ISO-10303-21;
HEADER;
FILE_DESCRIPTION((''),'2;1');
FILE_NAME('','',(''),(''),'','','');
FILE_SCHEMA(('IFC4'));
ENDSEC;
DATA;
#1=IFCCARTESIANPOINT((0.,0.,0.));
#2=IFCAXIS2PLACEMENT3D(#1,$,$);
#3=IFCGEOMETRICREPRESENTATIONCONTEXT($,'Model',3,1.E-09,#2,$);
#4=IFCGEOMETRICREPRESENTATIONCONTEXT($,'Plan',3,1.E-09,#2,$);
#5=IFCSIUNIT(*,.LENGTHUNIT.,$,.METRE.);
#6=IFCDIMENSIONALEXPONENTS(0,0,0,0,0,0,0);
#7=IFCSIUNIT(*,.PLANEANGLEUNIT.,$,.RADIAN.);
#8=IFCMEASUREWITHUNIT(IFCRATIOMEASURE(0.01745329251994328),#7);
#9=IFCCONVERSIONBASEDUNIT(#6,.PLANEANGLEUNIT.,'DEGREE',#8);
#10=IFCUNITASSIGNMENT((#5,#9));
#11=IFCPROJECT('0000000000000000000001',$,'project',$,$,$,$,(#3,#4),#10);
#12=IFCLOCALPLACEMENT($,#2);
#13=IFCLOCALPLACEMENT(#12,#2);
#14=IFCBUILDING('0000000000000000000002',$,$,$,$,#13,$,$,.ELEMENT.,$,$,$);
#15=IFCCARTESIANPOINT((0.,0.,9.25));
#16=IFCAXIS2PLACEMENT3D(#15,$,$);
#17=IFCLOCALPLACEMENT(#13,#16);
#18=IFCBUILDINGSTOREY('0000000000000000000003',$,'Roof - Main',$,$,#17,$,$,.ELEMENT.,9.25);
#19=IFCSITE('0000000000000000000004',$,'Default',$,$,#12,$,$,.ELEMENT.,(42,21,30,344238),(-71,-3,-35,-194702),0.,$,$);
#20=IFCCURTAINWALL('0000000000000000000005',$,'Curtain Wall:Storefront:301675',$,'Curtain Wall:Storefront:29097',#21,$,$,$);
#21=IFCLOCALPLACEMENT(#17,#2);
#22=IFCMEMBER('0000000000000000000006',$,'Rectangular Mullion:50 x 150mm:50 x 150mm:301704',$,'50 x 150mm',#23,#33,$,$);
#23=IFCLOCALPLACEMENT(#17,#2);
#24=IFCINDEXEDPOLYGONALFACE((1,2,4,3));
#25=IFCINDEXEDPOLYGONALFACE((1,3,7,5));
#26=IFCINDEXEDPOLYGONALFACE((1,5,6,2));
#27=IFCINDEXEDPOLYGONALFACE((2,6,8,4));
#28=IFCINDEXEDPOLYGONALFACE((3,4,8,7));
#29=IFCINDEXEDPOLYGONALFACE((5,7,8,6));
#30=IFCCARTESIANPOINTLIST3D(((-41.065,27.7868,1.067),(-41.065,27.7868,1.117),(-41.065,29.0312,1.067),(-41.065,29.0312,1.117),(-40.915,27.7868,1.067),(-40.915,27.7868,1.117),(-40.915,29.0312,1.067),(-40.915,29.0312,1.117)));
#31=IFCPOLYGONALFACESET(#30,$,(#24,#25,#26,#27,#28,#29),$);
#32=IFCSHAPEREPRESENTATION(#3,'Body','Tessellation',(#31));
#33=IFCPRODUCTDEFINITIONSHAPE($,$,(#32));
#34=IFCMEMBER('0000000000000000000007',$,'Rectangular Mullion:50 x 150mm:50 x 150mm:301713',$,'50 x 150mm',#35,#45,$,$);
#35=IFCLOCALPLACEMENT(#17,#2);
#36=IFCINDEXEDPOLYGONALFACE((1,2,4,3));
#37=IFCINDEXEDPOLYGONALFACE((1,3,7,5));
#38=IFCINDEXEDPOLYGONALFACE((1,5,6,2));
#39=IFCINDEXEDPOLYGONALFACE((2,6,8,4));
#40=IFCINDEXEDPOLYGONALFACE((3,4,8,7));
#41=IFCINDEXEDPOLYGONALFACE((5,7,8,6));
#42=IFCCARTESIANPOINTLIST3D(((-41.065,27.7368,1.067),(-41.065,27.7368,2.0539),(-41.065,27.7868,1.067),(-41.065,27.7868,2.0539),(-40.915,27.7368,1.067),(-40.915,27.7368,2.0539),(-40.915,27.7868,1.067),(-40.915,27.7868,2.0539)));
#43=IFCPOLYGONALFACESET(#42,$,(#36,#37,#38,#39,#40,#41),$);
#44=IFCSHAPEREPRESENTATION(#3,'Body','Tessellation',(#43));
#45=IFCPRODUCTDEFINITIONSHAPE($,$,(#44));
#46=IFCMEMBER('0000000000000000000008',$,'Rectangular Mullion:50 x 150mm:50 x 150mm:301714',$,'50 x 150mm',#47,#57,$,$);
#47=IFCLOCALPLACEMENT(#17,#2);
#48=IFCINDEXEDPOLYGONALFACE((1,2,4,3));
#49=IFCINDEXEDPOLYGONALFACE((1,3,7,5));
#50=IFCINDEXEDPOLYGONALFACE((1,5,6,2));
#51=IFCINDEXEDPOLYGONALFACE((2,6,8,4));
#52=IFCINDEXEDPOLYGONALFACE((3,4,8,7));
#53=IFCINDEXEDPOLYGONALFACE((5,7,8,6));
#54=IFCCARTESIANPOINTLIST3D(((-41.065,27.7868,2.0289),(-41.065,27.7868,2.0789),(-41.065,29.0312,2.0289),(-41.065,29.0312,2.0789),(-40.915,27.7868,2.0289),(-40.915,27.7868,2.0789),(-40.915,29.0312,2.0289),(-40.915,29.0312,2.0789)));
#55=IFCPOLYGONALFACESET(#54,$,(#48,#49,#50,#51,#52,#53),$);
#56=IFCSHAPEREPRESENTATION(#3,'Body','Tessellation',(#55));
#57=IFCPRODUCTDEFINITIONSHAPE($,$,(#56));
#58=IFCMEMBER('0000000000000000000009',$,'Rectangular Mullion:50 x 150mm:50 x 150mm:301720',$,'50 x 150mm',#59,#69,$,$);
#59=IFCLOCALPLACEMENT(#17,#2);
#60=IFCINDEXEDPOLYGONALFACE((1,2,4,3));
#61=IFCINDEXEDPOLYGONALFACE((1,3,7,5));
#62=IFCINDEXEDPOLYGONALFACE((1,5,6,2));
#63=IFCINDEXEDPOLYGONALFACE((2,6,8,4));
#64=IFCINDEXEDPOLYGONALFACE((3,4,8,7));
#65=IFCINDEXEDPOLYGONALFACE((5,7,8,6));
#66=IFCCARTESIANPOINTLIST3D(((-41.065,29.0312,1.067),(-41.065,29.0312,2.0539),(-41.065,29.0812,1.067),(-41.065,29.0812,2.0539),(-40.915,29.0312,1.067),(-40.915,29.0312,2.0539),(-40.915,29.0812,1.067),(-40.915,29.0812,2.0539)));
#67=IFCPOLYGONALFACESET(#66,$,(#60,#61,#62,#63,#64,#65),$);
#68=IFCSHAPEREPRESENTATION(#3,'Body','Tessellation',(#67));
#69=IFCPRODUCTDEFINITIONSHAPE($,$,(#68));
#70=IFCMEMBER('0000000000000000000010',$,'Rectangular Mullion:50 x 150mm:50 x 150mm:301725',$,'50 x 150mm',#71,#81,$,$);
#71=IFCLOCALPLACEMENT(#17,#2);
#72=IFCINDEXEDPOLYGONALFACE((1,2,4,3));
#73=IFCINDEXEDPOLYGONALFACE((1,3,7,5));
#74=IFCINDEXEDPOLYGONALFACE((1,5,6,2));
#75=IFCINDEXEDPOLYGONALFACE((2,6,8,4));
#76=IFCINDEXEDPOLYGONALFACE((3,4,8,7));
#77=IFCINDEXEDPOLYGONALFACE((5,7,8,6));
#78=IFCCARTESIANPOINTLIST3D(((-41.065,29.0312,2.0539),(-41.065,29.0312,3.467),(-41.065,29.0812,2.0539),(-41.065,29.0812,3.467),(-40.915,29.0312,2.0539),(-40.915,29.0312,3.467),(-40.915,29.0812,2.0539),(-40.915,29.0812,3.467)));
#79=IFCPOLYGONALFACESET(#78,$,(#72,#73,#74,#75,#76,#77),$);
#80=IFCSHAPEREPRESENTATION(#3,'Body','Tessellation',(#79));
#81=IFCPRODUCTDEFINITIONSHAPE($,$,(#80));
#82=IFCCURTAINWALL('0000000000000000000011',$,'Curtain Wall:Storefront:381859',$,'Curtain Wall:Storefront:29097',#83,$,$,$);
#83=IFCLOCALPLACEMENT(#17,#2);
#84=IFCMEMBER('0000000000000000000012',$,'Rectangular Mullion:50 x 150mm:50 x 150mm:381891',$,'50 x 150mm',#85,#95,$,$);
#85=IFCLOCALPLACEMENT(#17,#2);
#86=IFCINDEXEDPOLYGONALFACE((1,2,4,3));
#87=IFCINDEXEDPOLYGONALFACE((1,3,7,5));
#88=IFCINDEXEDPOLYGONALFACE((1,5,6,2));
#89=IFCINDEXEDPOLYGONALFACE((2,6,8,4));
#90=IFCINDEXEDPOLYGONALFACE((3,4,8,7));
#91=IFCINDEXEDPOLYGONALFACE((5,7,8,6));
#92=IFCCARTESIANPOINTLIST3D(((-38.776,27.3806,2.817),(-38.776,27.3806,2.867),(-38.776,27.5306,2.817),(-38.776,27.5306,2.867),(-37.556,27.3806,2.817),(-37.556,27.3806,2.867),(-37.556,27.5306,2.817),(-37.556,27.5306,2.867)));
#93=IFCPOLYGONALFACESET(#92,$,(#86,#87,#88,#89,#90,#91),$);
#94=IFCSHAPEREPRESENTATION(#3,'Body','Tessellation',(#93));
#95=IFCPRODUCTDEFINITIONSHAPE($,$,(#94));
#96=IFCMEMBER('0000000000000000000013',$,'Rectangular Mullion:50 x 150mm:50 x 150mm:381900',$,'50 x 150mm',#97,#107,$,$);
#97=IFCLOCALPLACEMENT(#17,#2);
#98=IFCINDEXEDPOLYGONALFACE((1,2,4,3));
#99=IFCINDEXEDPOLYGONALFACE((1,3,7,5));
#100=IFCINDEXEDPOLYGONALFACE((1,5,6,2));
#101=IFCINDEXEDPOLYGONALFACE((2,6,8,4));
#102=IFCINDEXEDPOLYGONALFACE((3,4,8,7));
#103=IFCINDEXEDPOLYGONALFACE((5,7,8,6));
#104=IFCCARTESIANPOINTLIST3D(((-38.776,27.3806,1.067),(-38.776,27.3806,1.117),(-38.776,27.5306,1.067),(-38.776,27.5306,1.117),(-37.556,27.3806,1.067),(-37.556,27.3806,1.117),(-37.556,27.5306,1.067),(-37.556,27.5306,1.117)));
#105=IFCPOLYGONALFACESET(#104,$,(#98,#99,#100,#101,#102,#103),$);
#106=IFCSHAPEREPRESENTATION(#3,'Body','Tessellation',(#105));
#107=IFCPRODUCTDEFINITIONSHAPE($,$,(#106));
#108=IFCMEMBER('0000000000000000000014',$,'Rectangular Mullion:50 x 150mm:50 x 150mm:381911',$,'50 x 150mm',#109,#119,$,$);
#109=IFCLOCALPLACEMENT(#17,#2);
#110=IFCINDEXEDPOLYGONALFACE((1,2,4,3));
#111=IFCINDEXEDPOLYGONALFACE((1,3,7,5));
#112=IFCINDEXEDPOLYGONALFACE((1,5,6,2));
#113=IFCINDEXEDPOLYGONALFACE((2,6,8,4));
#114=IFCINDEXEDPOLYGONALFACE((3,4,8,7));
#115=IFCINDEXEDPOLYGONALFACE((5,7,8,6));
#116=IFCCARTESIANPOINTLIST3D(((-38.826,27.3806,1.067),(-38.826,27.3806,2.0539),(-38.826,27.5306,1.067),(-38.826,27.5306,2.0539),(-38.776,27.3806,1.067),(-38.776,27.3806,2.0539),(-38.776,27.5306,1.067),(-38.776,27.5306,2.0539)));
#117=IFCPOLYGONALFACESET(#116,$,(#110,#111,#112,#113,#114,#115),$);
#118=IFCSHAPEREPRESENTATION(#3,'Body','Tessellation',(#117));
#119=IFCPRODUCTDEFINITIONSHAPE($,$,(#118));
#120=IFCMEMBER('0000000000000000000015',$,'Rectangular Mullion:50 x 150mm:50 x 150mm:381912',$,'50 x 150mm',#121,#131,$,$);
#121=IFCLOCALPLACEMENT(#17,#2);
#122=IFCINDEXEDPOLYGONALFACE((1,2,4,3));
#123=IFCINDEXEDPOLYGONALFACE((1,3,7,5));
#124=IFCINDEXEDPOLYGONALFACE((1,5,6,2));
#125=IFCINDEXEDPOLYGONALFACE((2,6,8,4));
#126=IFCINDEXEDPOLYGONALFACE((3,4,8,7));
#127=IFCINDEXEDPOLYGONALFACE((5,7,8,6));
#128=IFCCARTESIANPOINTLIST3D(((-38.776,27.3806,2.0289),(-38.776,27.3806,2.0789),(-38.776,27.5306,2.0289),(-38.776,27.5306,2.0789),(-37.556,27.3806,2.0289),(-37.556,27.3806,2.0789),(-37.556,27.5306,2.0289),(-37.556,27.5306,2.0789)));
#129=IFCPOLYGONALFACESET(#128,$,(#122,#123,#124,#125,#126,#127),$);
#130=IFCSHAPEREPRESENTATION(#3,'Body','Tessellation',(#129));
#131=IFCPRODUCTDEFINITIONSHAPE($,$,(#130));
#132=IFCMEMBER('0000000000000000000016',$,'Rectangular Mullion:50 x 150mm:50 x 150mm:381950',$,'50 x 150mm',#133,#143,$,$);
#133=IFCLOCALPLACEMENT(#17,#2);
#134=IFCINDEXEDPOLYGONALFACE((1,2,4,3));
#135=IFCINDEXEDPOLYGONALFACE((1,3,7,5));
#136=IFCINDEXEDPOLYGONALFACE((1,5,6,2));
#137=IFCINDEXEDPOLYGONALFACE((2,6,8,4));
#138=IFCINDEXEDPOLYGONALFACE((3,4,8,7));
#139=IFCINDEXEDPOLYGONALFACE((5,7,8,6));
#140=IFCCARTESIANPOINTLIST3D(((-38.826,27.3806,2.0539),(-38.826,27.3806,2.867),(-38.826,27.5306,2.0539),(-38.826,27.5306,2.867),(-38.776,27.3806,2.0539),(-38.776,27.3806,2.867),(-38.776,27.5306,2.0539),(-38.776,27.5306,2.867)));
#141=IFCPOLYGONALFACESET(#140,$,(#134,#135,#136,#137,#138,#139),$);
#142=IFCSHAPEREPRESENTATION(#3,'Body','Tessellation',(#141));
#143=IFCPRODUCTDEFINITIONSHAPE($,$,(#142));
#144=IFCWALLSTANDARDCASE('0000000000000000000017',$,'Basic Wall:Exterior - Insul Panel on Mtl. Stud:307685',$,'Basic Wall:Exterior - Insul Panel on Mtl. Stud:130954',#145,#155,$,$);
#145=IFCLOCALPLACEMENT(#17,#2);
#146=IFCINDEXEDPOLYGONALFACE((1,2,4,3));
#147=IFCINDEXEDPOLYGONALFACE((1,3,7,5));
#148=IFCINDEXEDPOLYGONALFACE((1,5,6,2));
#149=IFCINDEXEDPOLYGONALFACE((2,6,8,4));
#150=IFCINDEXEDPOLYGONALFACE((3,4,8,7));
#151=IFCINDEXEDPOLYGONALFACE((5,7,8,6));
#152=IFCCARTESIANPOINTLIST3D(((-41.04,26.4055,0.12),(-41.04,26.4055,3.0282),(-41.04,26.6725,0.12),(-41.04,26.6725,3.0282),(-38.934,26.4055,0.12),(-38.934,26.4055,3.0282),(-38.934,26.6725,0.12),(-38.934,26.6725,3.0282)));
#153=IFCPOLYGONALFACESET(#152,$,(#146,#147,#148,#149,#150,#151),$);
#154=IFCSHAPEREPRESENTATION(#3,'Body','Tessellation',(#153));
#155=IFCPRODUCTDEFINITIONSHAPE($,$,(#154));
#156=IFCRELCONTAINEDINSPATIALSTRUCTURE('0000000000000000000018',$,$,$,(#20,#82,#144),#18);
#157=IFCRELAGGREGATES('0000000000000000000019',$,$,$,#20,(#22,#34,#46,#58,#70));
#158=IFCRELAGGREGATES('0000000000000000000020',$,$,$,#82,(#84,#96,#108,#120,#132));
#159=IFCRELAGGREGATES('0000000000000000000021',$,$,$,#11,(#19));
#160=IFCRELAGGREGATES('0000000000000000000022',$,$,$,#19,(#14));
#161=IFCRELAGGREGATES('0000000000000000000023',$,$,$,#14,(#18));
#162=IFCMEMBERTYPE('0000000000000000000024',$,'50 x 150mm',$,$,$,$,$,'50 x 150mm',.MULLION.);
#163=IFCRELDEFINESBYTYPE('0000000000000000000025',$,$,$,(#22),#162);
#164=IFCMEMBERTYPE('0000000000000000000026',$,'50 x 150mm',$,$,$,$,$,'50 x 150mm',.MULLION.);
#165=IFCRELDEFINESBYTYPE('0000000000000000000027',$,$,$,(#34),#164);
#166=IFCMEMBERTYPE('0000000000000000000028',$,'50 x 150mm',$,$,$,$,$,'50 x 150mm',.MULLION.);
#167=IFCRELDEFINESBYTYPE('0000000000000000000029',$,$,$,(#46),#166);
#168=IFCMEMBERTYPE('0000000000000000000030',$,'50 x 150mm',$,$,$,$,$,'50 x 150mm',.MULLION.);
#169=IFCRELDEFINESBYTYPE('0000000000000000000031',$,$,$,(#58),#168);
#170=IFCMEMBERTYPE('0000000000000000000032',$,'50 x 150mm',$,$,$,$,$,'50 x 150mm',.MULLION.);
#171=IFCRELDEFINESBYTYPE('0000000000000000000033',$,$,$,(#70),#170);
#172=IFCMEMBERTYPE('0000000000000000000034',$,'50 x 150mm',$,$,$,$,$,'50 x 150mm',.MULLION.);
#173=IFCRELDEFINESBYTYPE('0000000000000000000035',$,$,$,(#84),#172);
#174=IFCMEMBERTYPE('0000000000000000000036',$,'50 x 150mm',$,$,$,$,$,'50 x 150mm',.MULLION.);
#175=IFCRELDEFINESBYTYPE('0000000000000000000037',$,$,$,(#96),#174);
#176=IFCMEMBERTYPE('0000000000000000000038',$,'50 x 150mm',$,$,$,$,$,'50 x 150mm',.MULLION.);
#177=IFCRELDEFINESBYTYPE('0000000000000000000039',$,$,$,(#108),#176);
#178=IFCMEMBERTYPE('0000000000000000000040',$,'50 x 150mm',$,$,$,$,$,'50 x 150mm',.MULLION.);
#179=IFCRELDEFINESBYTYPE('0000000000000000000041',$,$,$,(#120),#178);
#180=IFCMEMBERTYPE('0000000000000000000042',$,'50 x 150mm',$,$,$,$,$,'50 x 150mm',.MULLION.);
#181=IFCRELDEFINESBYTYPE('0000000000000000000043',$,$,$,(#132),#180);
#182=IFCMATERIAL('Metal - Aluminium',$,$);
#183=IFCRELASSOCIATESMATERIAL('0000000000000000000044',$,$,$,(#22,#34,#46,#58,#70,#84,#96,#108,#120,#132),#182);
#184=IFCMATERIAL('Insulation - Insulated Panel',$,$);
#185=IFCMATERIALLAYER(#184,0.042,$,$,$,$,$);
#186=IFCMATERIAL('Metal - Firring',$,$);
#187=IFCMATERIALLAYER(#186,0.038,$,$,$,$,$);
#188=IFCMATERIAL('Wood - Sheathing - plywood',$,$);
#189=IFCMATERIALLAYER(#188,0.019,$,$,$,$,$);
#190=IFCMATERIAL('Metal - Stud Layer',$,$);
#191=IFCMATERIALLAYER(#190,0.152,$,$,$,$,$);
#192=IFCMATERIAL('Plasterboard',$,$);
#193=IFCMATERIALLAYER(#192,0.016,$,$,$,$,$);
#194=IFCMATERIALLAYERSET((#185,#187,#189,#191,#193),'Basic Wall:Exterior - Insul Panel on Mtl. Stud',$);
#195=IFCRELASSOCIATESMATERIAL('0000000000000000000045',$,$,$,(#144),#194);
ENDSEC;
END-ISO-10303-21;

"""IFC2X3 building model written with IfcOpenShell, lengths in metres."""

from ifc_helpers import new_model, entity, si_unit, converted_unit, frame, frame_2d, origin, origin_2d_with_axis, place, context, project, spatial, rectangle, extrude, source, transform, mapped, material, layer, layer_set, layer_usage, type_object, type_shapes, element, aggregate, save


model = new_model("IFC2X3")

# Units and contexts
model_context = context("Model", 3, precision=1e-09, world=origin())
plan_context = context("Plan", 3, precision=1e-09, world=origin())
ifc_project = project(units=[si_unit("LENGTHUNIT", "METRE"), converted_unit("PLANEANGLEUNIT", "DEGREE", entity("IfcRatioMeasure", 0.01745329251994328), si_unit("PLANEANGLEUNIT", "RADIAN"), dimensions=[0, 0, 0, 0, 0, 0, 0])], contexts=[model_context, plan_context])

# Site, building, storey
site_placement = place(None, origin())
site = spatial("IfcSite", under=ifc_project, at=site_placement, Name="Default", CompositionType="ELEMENT", RefLatitude=(42, 21, 30, 344238), RefLongitude=(-71, -3, -35, -194702), RefElevation=0.0)
building_placement = place(site_placement, origin())
building = spatial("IfcBuilding", under=site, at=building_placement, CompositionType="ELEMENT")
storey_placement = place(building_placement, frame((0.0, 0.0, 9.25)))
storey = spatial("IfcBuildingStorey", under=building, at=storey_placement, Name="Roof - Main", CompositionType="ELEMENT", Elevation=9.25)

# Curtain walls, members
curtain_wall_1_placement = place(storey_placement, origin())
curtain_wall_1 = element("IfcCurtainWall", 1, at=curtain_wall_1_placement, inside=storey, Name="Curtain Wall:Storefront:301675", ObjectType="Curtain Wall:Storefront:29097")
ifc_material_1 = material(Name="Metal - Aluminium")
member_type_1 = type_object("IfcMemberType", Name="50 x 150mm", ElementType="50 x 150mm", PredefinedType="MULLION")
shared_shape_1 = source(origin(), model_context, "Body", "SweptSolid", [
    extrude(rectangle(XDim=0.05, YDim=0.15, at=origin_2d_with_axis()), frame((-0.025, 0.0, -1.2444), z_axis=(0.0, 0.0, 1.0), x_axis=(-1.0, 0.0, 0.0)), (0.0, 0.0, 1.0), 1.2444),
])
type_shapes(member_type_1, [shared_shape_1])
member_1_placement = place(storey_placement, frame((-40.99, 27.7868, 1.067), z_axis=(0.0, -1.0, 0.0), x_axis=(0.0, 0.0, -1.0)))
member_1 = element("IfcMember", 2, at=member_1_placement, type_object=member_type_1, material=ifc_material_1, Name="Rectangular Mullion:50 x 150mm:50 x 150mm:301704", ObjectType="50 x 150mm", context=model_context, shape_type="MappedRepresentation", body=[
    mapped(shared_shape_1, transform((0.0, 0.0, 0.0), scale=1.0)),
])
member_type_2 = type_object("IfcMemberType", Name="50 x 150mm", ElementType="50 x 150mm", PredefinedType="MULLION")
shared_shape_2 = source(origin(), model_context, "Body", "SweptSolid", [
    extrude(rectangle(XDim=0.05, YDim=0.15, at=origin_2d_with_axis()), frame((-0.025, 0.0, -0.9869), z_axis=(0.0, 0.0, 1.0), x_axis=(-1.0, 0.0, 0.0)), (0.0, 0.0, 1.0), 0.9869),
])
type_shapes(member_type_2, [shared_shape_2])
member_2_placement = place(storey_placement, frame((-40.99, 27.7368, 2.0539), z_axis=(0.0, 0.0, 1.0), x_axis=(0.0, -1.0, 0.0)))
member_2 = element("IfcMember", 3, at=member_2_placement, type_object=member_type_2, material=ifc_material_1, Name="Rectangular Mullion:50 x 150mm:50 x 150mm:301713", ObjectType="50 x 150mm", context=model_context, shape_type="MappedRepresentation", body=[
    mapped(shared_shape_2, transform((0.0, 0.0, 0.0), scale=1.0)),
])
member_type_3 = type_object("IfcMemberType", Name="50 x 150mm", ElementType="50 x 150mm", PredefinedType="MULLION")
shared_shape_3 = source(origin(), model_context, "Body", "SweptSolid", [
    extrude(rectangle(XDim=0.05, YDim=0.15, at=origin_2d_with_axis()), frame((0.0, 0.0, -1.2444), z_axis=(0.0, 0.0, 1.0), x_axis=(-1.0, 0.0, 0.0)), (0.0, 0.0, 1.0), 1.2444),
])
type_shapes(member_type_3, [shared_shape_3])
member_3_placement = place(storey_placement, frame((-40.99, 29.0312, 2.0539), z_axis=(0.0, 1.0, 0.0), x_axis=(0.0, 0.0, 1.0)))
member_3 = element("IfcMember", 4, at=member_3_placement, type_object=member_type_3, material=ifc_material_1, Name="Rectangular Mullion:50 x 150mm:50 x 150mm:301714", ObjectType="50 x 150mm", context=model_context, shape_type="MappedRepresentation", body=[
    mapped(shared_shape_3, transform((0.0, 0.0, 0.0), scale=1.0)),
])
member_type_4 = type_object("IfcMemberType", Name="50 x 150mm", ElementType="50 x 150mm", PredefinedType="MULLION")
shared_shape_4 = source(origin(), model_context, "Body", "SweptSolid", [
    extrude(rectangle(XDim=0.05, YDim=0.15, at=origin_2d_with_axis()), frame((0.0, 0.0, -0.9869), z_axis=(0.0, 0.0, 1.0), x_axis=(-1.0, 0.0, 0.0)), (0.0, 0.0, 1.0), 0.9869),
])
type_shapes(member_type_4, [shared_shape_4])
member_4_placement = place(storey_placement, frame((-40.99, 29.0562, 1.067), z_axis=(0.0, 0.0, -1.0), x_axis=(0.0, 1.0, 0.0)))
member_4 = element("IfcMember", 5, at=member_4_placement, type_object=member_type_4, material=ifc_material_1, Name="Rectangular Mullion:50 x 150mm:50 x 150mm:301720", ObjectType="50 x 150mm", context=model_context, shape_type="MappedRepresentation", body=[
    mapped(shared_shape_4, transform((0.0, 0.0, 0.0), scale=1.0)),
])
member_type_5 = type_object("IfcMemberType", Name="50 x 150mm", ElementType="50 x 150mm", PredefinedType="MULLION")
shared_shape_5 = source(origin(), model_context, "Body", "SweptSolid", [
    extrude(rectangle(XDim=0.05, YDim=0.15, at=origin_2d_with_axis()), frame((0.0, 0.0, -1.4131), z_axis=(0.0, 0.0, 1.0), x_axis=(-1.0, 0.0, 0.0)), (0.0, 0.0, 1.0), 1.4131),
])
type_shapes(member_type_5, [shared_shape_5])
member_5_placement = place(storey_placement, frame((-40.99, 29.0562, 2.0539), z_axis=(0.0, 0.0, -1.0), x_axis=(0.0, 1.0, 0.0)))
member_5 = element("IfcMember", 6, at=member_5_placement, type_object=member_type_5, material=ifc_material_1, Name="Rectangular Mullion:50 x 150mm:50 x 150mm:301725", ObjectType="50 x 150mm", context=model_context, shape_type="MappedRepresentation", body=[
    mapped(shared_shape_5, transform((0.0, 0.0, 0.0), scale=1.0)),
])
curtain_wall_2_placement = place(storey_placement, origin())
curtain_wall_2 = element("IfcCurtainWall", 7, at=curtain_wall_2_placement, inside=storey, Name="Curtain Wall:Storefront:381859", ObjectType="Curtain Wall:Storefront:29097")
member_type_6 = type_object("IfcMemberType", Name="50 x 150mm", ElementType="50 x 150mm", PredefinedType="MULLION")
shared_shape_6 = source(origin(), model_context, "Body", "SweptSolid", [
    extrude(rectangle(XDim=0.05, YDim=0.15, at=origin_2d_with_axis()), frame((-0.025, 0.0, -1.22), z_axis=(0.0, 0.0, 1.0), x_axis=(-1.0, 0.0, 0.0)), (0.0, 0.0, 1.0), 1.22),
])
type_shapes(member_type_6, [shared_shape_6])
member_6_placement = place(storey_placement, frame((-37.556, 27.4556, 2.867), z_axis=(1.0, 0.0, 0.0), x_axis=(0.0, 0.0, 1.0)))
member_6 = element("IfcMember", 8, at=member_6_placement, type_object=member_type_6, material=ifc_material_1, Name="Rectangular Mullion:50 x 150mm:50 x 150mm:381891", ObjectType="50 x 150mm", context=model_context, shape_type="MappedRepresentation", body=[
    mapped(shared_shape_6, transform((0.0, 0.0, 0.0), scale=1.0)),
])
member_type_7 = type_object("IfcMemberType", Name="50 x 150mm", ElementType="50 x 150mm", PredefinedType="MULLION")
shared_shape_7 = source(origin(), model_context, "Body", "SweptSolid", [
    extrude(rectangle(XDim=0.05, YDim=0.15, at=origin_2d_with_axis()), frame((-0.025, 0.0, -1.22), z_axis=(0.0, 0.0, 1.0), x_axis=(-1.0, 0.0, 0.0)), (0.0, 0.0, 1.0), 1.22),
])
type_shapes(member_type_7, [shared_shape_7])
member_7_placement = place(storey_placement, frame((-38.776, 27.4556, 1.067), z_axis=(-1.0, 0.0, 0.0), x_axis=(0.0, 0.0, -1.0)))
member_7 = element("IfcMember", 9, at=member_7_placement, type_object=member_type_7, material=ifc_material_1, Name="Rectangular Mullion:50 x 150mm:50 x 150mm:381900", ObjectType="50 x 150mm", context=model_context, shape_type="MappedRepresentation", body=[
    mapped(shared_shape_7, transform((0.0, 0.0, 0.0), scale=1.0)),
])
member_type_8 = type_object("IfcMemberType", Name="50 x 150mm", ElementType="50 x 150mm", PredefinedType="MULLION")
shared_shape_8 = source(origin(), model_context, "Body", "SweptSolid", [
    extrude(rectangle(XDim=0.05, YDim=0.15, at=origin_2d_with_axis()), frame((-0.025, 0.0, -0.9869), z_axis=(0.0, 0.0, 1.0), x_axis=(-1.0, 0.0, 0.0)), (0.0, 0.0, 1.0), 0.9869),
])
type_shapes(member_type_8, [shared_shape_8])
member_8_placement = place(storey_placement, frame((-38.826, 27.4556, 2.0539), z_axis=(0.0, 0.0, 1.0), x_axis=(-1.0, 0.0, 0.0)))
member_8 = element("IfcMember", 10, at=member_8_placement, type_object=member_type_8, material=ifc_material_1, Name="Rectangular Mullion:50 x 150mm:50 x 150mm:381911", ObjectType="50 x 150mm", context=model_context, shape_type="MappedRepresentation", body=[
    mapped(shared_shape_8, transform((0.0, 0.0, 0.0), scale=1.0)),
])
member_type_9 = type_object("IfcMemberType", Name="50 x 150mm", ElementType="50 x 150mm", PredefinedType="MULLION")
shared_shape_9 = source(origin(), model_context, "Body", "SweptSolid", [
    extrude(rectangle(XDim=0.05, YDim=0.15, at=origin_2d_with_axis()), frame((0.0, 0.0, -1.22), z_axis=(0.0, 0.0, 1.0), x_axis=(-1.0, 0.0, 0.0)), (0.0, 0.0, 1.0), 1.22),
])
type_shapes(member_type_9, [shared_shape_9])
member_9_placement = place(storey_placement, frame((-37.556, 27.4556, 2.0539), z_axis=(1.0, 0.0, 0.0), x_axis=(0.0, 0.0, 1.0)))
member_9 = element("IfcMember", 11, at=member_9_placement, type_object=member_type_9, material=ifc_material_1, Name="Rectangular Mullion:50 x 150mm:50 x 150mm:381912", ObjectType="50 x 150mm", context=model_context, shape_type="MappedRepresentation", body=[
    mapped(shared_shape_9, transform((0.0, 0.0, 0.0), scale=1.0)),
])
member_type_10 = type_object("IfcMemberType", Name="50 x 150mm", ElementType="50 x 150mm", PredefinedType="MULLION")
shared_shape_10 = source(origin(), model_context, "Body", "SweptSolid", [
    extrude(rectangle(XDim=0.05, YDim=0.15, at=origin_2d_with_axis()), frame((-0.025, 0.0, -0.8131), z_axis=(0.0, 0.0, 1.0), x_axis=(-1.0, 0.0, 0.0)), (0.0, 0.0, 1.0), 0.8131),
])
type_shapes(member_type_10, [shared_shape_10])
member_10_placement = place(storey_placement, frame((-38.826, 27.4556, 2.867), z_axis=(0.0, 0.0, 1.0), x_axis=(-1.0, 0.0, 0.0)))
member_10 = element("IfcMember", 12, at=member_10_placement, type_object=member_type_10, material=ifc_material_1, Name="Rectangular Mullion:50 x 150mm:50 x 150mm:381950", ObjectType="50 x 150mm", context=model_context, shape_type="MappedRepresentation", body=[
    mapped(shared_shape_10, transform((0.0, 0.0, 0.0), scale=1.0)),
])

aggregate(curtain_wall_1, [member_1, member_2, member_3, member_4, member_5])
aggregate(curtain_wall_2, [member_6, member_7, member_8, member_9, member_10])

# Wall
ifc_material_2 = material(Name="Insulation - Insulated Panel")
ifc_layer_1 = layer(ifc_material_2, 0.042)
ifc_material_3 = material(Name="Metal - Firring")
ifc_layer_2 = layer(ifc_material_3, 0.038)
ifc_material_4 = material(Name="Wood - Sheathing - plywood")
ifc_layer_3 = layer(ifc_material_4, 0.019)
ifc_material_5 = material(Name="Metal - Stud Layer")
ifc_layer_4 = layer(ifc_material_5, 0.152)
ifc_material_6 = material(Name="Plasterboard")
ifc_layer_5 = layer(ifc_material_6, 0.016)
ifc_layer_set = layer_set([ifc_layer_1, ifc_layer_2, ifc_layer_3, ifc_layer_4, ifc_layer_5], Name="Basic Wall:Exterior - Insul Panel on Mtl. Stud")
ifc_layer_usage_1 = layer_usage(ifc_layer_set, "AXIS2", "POSITIVE", -0.1335)
wall_1_placement = place(storey_placement, frame((-41.04, 26.539, 0.12)))
element("IfcWallStandardCase", 13, at=wall_1_placement, inside=storey, material=ifc_layer_usage_1, Name="Basic Wall:Exterior - Insul Panel on Mtl. Stud:307685", ObjectType="Basic Wall:Exterior - Insul Panel on Mtl. Stud:130954", context=model_context, shape_type="SweptSolid", body=[
    extrude(rectangle(XDim=2.106, YDim=0.267, at=frame_2d((1.053, 0.0), x_axis=(-1.0, 0.0))), origin(), (0.0, 0.0, 1.0), 2.9082),
])

save(model, "model.ifc")
